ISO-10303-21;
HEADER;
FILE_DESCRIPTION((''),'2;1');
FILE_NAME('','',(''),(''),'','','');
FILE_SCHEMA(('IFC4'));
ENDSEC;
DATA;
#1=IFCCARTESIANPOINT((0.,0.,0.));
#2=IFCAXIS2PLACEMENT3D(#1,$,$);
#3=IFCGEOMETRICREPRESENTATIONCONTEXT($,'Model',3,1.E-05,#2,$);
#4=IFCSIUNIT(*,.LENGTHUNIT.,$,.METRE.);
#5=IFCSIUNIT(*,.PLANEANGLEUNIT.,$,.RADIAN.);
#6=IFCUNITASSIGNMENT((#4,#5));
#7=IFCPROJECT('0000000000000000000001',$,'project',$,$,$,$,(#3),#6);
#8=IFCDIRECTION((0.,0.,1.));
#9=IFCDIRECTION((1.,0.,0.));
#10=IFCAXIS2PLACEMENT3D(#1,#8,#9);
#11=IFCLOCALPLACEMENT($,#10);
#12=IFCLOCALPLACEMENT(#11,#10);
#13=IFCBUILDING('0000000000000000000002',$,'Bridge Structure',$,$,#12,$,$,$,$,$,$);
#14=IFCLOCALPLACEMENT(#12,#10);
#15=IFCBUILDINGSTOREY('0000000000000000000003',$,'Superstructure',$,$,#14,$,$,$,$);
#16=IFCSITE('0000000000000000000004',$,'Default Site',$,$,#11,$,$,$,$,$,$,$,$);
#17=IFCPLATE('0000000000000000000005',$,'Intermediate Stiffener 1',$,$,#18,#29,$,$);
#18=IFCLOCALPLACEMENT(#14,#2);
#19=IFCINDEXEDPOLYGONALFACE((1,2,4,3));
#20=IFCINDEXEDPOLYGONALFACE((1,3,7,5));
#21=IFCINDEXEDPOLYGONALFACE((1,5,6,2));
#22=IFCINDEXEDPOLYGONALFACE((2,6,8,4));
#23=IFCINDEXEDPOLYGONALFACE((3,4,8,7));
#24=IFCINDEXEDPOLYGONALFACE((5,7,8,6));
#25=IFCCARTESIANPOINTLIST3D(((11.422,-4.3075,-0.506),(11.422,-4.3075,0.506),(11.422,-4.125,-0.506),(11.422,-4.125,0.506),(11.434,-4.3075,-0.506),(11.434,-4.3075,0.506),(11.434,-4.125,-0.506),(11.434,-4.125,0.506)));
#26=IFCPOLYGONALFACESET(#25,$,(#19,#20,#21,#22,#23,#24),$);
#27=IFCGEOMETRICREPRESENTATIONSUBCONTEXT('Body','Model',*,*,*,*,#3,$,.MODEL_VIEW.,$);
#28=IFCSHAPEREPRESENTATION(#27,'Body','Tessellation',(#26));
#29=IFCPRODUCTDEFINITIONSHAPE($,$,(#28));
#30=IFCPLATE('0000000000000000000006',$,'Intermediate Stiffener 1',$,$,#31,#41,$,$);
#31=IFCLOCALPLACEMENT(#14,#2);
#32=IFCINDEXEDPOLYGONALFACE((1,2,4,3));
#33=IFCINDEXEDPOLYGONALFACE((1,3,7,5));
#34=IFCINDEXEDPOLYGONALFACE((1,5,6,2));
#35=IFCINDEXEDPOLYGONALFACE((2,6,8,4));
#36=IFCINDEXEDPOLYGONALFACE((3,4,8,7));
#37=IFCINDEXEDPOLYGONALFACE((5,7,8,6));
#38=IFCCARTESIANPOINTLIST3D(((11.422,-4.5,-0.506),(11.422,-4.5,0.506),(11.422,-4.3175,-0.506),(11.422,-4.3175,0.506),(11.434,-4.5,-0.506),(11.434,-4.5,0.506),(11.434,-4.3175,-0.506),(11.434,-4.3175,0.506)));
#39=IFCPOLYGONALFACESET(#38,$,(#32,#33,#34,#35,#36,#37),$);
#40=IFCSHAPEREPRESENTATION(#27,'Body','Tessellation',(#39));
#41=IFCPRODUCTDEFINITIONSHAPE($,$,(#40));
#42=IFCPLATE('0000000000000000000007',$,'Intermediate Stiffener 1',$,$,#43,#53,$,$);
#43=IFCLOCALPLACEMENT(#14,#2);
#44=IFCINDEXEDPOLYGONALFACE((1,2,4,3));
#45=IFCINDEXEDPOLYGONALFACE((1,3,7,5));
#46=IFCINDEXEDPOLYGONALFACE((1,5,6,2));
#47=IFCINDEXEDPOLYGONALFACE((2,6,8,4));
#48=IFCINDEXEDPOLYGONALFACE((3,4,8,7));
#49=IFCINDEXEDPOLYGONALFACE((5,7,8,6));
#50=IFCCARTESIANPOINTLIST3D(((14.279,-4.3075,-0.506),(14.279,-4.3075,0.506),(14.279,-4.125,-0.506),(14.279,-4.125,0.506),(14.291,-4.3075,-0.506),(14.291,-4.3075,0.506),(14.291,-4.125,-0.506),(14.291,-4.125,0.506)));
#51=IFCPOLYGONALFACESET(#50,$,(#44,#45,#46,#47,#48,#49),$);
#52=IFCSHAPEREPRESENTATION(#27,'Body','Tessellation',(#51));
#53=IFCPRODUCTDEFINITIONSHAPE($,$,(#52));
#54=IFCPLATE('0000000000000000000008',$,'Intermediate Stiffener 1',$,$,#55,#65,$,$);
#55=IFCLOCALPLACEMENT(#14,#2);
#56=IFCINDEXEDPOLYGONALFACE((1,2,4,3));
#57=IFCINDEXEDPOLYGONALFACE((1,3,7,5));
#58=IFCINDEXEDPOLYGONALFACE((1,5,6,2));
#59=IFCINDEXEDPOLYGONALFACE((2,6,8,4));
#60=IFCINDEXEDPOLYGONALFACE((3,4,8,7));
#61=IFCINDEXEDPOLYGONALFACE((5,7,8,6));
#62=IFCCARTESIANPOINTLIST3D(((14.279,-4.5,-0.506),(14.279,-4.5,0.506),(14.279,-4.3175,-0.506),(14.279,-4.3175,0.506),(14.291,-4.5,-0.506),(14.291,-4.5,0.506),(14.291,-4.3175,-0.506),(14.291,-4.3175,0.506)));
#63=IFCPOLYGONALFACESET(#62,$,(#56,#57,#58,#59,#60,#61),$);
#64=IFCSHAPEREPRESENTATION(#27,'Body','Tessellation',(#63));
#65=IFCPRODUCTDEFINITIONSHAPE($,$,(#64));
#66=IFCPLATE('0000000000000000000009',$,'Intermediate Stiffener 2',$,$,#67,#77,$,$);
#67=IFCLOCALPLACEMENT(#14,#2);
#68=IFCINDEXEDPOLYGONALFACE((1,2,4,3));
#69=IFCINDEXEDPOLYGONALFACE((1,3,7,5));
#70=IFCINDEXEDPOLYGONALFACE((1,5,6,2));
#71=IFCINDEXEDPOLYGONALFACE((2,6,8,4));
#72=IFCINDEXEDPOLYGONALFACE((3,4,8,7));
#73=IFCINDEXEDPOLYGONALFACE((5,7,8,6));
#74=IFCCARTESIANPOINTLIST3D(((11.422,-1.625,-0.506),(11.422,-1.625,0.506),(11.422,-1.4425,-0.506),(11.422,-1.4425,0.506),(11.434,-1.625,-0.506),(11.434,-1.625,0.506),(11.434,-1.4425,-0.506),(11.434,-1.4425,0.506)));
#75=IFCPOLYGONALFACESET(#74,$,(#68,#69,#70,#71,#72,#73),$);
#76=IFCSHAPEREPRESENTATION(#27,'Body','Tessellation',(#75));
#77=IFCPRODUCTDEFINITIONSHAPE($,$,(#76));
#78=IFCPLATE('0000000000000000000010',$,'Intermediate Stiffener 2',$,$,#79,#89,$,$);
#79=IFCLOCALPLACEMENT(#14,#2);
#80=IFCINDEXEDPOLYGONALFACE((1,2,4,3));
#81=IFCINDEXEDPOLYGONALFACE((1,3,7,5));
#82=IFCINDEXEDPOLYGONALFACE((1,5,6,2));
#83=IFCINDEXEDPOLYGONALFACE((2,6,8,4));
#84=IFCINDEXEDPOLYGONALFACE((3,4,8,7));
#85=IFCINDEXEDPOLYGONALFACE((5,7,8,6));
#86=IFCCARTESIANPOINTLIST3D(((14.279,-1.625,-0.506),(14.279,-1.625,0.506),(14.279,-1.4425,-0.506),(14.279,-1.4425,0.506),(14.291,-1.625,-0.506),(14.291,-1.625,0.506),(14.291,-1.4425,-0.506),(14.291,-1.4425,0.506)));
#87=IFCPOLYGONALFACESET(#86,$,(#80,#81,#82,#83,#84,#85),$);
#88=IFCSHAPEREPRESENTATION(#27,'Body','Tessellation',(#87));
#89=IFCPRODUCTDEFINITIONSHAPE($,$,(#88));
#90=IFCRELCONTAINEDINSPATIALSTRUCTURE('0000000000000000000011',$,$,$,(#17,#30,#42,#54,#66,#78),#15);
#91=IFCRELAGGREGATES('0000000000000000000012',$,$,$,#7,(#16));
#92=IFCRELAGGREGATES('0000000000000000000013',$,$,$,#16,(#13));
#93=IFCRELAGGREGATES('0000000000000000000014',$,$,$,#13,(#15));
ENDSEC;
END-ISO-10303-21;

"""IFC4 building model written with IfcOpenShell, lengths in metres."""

from ifc_helpers import new_model, si_unit, frame, origin, origin_with_axes, origin_2d_with_axis, place, context, subcontext, project, spatial, rectangle, extrude, element, save


model = new_model("IFC4")

# Units and contexts
model_context = context("Model", 3, precision=1e-05, world=origin())
body_context = subcontext(model_context, "Body", "Model", "MODEL_VIEW")
ifc_project = project(units=[si_unit("LENGTHUNIT", "METRE"), si_unit("PLANEANGLEUNIT", "RADIAN")], contexts=[model_context])

# Site, building, storey
site_placement = place(None, origin_with_axes())
site = spatial("IfcSite", under=ifc_project, at=site_placement, Name="Default Site")
building_placement = place(site_placement, origin_with_axes())
building = spatial("IfcBuilding", under=site, at=building_placement, Name="Bridge Structure")
storey_placement = place(building_placement, origin_with_axes())
storey = spatial("IfcBuildingStorey", under=building, at=storey_placement, Name="Superstructure")

# Plates
for number, where, z_axis, x_axis, name in (
    (1, (11.428, -4.2163, -0.506), (0.0, 0.0, 1.0), (1.0, 0.0, 0.0), "Intermediate Stiffener 1"),
    (2, (11.428, -4.4088, -0.506), (0.0, 0.0, 1.0), (1.0, 0.0, 0.0), "Intermediate Stiffener 1"),
    (3, (14.285, -4.2163, -0.506), (0.0, 0.0, 1.0), (1.0, 0.0, 0.0), "Intermediate Stiffener 1"),
    (4, (14.285, -4.4088, -0.506), (0.0, 0.0, 1.0), (1.0, 0.0, 0.0), "Intermediate Stiffener 1"),
    (5, (11.428, -1.5337, -0.506), (0.0, 0.0, 1.0), (1.0, 0.0, 0.0), "Intermediate Stiffener 2"),
    (6, (14.285, -1.5337, -0.506), (0.0, 0.0, 1.0), (1.0, 0.0, 0.0), "Intermediate Stiffener 2"),
):
    element("IfcPlate", number, at=place(storey_placement, frame(where, z_axis=z_axis, x_axis=x_axis)), inside=storey, Name=name, context=body_context, shape_type="SweptSolid", body=[
        extrude(rectangle(XDim=0.012, YDim=0.1825, at=origin_2d_with_axis()), origin_with_axes(), (0.0, 0.0, 1.0), 1.012),
    ])

save(model, "model.ifc")
